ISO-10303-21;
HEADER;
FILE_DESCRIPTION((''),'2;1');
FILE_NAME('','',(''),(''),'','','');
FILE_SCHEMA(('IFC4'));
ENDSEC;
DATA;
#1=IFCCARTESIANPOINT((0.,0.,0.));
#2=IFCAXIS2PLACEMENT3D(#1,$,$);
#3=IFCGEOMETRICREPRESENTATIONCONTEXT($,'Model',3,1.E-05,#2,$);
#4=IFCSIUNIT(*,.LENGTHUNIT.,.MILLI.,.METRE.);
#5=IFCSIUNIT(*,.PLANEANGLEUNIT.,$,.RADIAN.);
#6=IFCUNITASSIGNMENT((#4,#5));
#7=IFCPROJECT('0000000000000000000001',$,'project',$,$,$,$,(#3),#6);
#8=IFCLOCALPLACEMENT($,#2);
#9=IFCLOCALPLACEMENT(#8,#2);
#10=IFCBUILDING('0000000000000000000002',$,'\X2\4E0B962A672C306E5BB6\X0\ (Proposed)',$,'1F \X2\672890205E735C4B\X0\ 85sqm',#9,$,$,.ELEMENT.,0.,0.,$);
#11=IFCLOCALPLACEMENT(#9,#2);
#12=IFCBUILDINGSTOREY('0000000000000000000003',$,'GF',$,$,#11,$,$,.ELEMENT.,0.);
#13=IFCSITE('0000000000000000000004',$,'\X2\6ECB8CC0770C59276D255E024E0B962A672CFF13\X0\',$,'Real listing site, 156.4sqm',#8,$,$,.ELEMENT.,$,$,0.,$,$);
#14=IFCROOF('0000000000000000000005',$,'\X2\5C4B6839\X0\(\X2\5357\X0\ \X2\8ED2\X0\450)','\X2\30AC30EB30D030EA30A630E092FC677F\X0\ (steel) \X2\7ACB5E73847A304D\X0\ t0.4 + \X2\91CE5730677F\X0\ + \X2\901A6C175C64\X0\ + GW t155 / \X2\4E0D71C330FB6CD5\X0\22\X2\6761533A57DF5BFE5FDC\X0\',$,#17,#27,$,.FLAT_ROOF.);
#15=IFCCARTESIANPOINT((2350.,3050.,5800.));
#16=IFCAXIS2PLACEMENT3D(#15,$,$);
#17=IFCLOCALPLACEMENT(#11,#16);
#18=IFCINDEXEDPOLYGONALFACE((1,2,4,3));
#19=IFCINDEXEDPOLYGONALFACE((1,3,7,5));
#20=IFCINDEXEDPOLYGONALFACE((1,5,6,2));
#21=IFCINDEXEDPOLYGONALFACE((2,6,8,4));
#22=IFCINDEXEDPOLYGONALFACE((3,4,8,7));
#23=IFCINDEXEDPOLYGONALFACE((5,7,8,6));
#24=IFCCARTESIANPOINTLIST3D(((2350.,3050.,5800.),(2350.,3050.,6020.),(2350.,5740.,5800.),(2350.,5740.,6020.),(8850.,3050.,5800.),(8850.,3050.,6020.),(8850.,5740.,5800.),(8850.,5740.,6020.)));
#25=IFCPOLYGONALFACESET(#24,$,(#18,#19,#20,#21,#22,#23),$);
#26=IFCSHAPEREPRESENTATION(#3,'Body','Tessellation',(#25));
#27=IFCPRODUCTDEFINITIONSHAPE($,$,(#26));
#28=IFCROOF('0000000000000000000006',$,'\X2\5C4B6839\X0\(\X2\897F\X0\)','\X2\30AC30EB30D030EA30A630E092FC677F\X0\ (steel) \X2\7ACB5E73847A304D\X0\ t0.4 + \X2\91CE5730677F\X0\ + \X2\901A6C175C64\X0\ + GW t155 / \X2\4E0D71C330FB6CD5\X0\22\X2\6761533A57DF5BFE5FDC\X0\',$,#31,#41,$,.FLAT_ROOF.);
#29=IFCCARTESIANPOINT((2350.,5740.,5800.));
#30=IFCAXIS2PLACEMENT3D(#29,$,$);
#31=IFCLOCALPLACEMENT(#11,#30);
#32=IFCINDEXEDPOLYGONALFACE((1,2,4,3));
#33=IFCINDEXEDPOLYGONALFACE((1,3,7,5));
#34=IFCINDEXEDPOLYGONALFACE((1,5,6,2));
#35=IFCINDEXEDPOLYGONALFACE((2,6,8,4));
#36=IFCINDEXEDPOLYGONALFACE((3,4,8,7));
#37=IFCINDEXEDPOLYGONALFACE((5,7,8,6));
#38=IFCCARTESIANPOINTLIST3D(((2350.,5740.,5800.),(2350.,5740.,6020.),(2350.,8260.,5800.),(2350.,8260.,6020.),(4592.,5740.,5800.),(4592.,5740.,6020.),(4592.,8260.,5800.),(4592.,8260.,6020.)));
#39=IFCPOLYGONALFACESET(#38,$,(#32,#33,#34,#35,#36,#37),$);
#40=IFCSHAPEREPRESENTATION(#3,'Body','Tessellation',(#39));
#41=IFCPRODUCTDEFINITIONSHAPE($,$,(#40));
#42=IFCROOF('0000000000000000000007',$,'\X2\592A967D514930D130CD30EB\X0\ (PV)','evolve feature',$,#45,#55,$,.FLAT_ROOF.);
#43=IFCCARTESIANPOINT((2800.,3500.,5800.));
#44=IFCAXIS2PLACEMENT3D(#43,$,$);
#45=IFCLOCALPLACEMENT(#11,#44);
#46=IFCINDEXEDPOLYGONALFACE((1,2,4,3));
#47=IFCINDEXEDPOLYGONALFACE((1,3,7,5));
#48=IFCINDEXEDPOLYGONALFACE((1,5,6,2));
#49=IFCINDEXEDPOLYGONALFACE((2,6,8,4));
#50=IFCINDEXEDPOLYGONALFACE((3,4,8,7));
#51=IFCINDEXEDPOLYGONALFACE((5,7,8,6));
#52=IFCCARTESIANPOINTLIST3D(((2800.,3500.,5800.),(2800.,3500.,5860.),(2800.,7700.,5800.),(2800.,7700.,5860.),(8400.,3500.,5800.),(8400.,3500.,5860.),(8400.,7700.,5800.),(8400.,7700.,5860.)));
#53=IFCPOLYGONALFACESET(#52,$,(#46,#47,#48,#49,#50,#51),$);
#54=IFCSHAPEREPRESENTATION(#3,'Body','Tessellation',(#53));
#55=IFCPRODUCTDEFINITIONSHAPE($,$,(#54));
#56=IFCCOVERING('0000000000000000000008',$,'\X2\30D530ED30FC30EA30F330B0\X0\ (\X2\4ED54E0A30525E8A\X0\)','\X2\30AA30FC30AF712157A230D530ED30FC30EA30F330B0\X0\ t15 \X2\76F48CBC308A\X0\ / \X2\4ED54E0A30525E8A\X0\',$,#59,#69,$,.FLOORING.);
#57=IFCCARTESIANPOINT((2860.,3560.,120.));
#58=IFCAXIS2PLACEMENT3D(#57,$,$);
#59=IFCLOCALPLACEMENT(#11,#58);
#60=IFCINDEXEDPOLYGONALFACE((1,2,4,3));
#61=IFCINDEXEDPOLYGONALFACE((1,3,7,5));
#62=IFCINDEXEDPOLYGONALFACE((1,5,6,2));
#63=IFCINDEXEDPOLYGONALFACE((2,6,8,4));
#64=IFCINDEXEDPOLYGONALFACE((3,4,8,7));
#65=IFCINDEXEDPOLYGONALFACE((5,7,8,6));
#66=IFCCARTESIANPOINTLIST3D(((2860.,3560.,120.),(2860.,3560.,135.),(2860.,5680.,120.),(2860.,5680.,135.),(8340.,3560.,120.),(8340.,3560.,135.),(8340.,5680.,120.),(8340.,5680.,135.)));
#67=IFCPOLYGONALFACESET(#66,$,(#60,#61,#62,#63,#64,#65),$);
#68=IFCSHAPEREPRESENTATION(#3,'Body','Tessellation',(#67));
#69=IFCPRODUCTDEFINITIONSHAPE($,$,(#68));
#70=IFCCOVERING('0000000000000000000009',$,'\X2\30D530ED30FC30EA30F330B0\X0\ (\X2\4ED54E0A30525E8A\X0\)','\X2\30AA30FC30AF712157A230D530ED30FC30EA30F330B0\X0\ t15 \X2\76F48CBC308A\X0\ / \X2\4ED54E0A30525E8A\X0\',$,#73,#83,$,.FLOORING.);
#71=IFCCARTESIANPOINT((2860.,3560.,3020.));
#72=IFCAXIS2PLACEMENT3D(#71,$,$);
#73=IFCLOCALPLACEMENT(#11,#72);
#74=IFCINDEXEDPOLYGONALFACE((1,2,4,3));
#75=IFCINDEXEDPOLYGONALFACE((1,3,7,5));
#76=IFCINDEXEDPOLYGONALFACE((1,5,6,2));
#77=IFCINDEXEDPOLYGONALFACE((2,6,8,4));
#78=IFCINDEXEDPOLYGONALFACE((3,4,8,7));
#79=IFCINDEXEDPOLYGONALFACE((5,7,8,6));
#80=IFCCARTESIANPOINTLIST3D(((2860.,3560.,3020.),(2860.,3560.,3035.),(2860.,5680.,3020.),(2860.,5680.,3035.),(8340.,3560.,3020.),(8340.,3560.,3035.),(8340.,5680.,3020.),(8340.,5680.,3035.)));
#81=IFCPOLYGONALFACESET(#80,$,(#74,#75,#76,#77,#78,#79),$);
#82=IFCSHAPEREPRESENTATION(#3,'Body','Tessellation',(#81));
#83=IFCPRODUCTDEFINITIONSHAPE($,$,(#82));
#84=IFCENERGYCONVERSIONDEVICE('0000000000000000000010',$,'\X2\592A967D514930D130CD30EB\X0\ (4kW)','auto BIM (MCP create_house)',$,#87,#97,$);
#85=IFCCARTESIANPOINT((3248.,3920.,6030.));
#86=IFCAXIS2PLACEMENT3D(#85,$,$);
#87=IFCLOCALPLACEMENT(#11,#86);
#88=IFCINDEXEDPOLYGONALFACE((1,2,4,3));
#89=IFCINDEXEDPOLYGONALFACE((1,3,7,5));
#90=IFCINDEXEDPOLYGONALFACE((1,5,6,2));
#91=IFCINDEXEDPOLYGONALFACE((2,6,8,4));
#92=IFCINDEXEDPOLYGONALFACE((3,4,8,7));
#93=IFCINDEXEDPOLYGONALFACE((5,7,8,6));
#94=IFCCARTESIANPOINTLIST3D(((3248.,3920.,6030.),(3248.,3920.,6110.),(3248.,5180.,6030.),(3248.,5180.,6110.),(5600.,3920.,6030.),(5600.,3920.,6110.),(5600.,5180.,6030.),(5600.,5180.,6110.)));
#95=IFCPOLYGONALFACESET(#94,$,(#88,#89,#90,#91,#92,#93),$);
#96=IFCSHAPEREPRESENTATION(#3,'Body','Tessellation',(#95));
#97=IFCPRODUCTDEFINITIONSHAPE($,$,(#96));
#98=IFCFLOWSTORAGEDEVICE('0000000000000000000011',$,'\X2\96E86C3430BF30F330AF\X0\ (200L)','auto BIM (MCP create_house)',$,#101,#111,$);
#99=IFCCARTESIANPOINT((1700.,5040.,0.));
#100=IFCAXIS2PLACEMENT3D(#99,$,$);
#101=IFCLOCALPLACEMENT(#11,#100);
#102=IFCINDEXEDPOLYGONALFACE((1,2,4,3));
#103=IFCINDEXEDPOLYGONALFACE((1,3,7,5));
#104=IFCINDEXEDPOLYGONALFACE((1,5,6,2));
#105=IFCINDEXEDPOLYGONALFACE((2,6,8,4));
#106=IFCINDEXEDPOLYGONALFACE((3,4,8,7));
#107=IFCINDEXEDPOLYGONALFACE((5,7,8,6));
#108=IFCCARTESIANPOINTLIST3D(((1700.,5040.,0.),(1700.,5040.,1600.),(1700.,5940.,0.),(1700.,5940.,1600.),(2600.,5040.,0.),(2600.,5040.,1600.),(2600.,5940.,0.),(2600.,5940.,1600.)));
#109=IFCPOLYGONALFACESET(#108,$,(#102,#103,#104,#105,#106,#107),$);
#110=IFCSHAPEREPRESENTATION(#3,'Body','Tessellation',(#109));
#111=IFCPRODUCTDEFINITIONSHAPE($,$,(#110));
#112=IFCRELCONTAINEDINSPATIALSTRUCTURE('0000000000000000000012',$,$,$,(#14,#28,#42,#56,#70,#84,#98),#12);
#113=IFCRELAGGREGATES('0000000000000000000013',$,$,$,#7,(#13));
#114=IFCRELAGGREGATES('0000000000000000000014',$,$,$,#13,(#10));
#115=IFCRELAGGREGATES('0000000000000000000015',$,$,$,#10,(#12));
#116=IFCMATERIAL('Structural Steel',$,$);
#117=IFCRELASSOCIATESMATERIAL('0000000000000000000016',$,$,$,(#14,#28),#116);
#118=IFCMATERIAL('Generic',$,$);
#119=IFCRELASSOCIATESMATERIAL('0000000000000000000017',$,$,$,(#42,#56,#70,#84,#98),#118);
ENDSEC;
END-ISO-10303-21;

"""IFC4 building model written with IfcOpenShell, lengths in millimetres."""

from ifc_helpers import new_model, si_unit, frame, frame_2d, origin, place, context, project, spatial, rectangle, extrude, material, element, save


model = new_model("IFC4")

# Units and contexts
model_context = context("Model", 3, precision=1e-05, world=origin())
ifc_project = project(units=[si_unit("LENGTHUNIT", "METRE", prefix="MILLI"), si_unit("PLANEANGLEUNIT", "RADIAN")], contexts=[model_context])

# Site, building, storey
site_placement = place(None, origin())
site = spatial("IfcSite", under=ifc_project, at=site_placement, Name="滋賀県大津市下阪本３", ObjectType="Real listing site, 156.4sqm", CompositionType="ELEMENT", RefElevation=0.0)
building_placement = place(site_placement, origin())
building = spatial("IfcBuilding", under=site, at=building_placement, Name="下阪本の家 (Proposed)", ObjectType="1F 木造平屋 85sqm", CompositionType="ELEMENT", ElevationOfRefHeight=0.0, ElevationOfTerrain=0.0)
storey_placement = place(building_placement, origin())
storey = spatial("IfcBuildingStorey", under=building, at=storey_placement, Name="GF", CompositionType="ELEMENT", Elevation=0.0)

# Shared definitions
ifc_material_1 = material(Name="Generic")

# Roofs
ifc_material_2 = material(Name="Structural Steel")
roof_1_placement = place(storey_placement, frame((2350.0, 3050.0, 5800.0)))
element("IfcRoof", 1, at=roof_1_placement, inside=storey, material=ifc_material_2, Name="屋根(南 軒450)", Description="ガルバリウム鋼板 (steel) 立平葺き t0.4 + 野地板 + 通気層 + GW t155 / 不燃・法22条区域対応", PredefinedType="FLAT_ROOF", context=model_context, shape_type="SweptSolid", body=[
    extrude(rectangle(XDim=6500.0, YDim=2690.0, at=frame_2d((3250.0, 1345.0))), frame((2350.0, 3050.0, 5800.0)), (0.0, 0.0, 1.0), 220.0),
])
roof_2_placement = place(storey_placement, frame((2350.0, 5740.0, 5800.0)))
element("IfcRoof", 2, at=roof_2_placement, inside=storey, material=ifc_material_2, Name="屋根(西)", Description="ガルバリウム鋼板 (steel) 立平葺き t0.4 + 野地板 + 通気層 + GW t155 / 不燃・法22条区域対応", PredefinedType="FLAT_ROOF", context=model_context, shape_type="SweptSolid", body=[
    extrude(rectangle(XDim=2242.0, YDim=2520.0, at=frame_2d((1121.0, 1260.0))), frame((2350.0, 5740.0, 5800.0)), (0.0, 0.0, 1.0), 220.0),
])
roof_3_placement = place(storey_placement, frame((2800.0, 3500.0, 5800.0)))
element("IfcRoof", 3, at=roof_3_placement, inside=storey, material=ifc_material_1, Name="太陽光パネル (PV)", Description="evolve feature", PredefinedType="FLAT_ROOF", context=model_context, shape_type="SweptSolid", body=[
    extrude(rectangle(XDim=5600.0, YDim=4200.0, at=frame_2d((2800.0, 2100.0))), frame((2800.0, 3500.0, 5800.0)), (0.0, 0.0, 1.0), 60.0),
])

# Coverings
covering_1_placement = place(storey_placement, frame((2860.0, 3560.0, 120.0)))
element("IfcCovering", 4, at=covering_1_placement, inside=storey, material=ifc_material_1, Name="フローリング (仕上げ床)", Description="オーク無垢フローリング t15 直貼り / 仕上げ床", PredefinedType="FLOORING", context=model_context, shape_type="SweptSolid", body=[
    extrude(rectangle(XDim=5480.0, YDim=2120.0, at=frame_2d((2740.0, 1060.0))), frame((2860.0, 3560.0, 120.0)), (0.0, 0.0, 1.0), 15.0),
])
covering_2_placement = place(storey_placement, frame((2860.0, 3560.0, 3020.0)))
element("IfcCovering", 5, at=covering_2_placement, inside=storey, material=ifc_material_1, Name="フローリング (仕上げ床)", Description="オーク無垢フローリング t15 直貼り / 仕上げ床", PredefinedType="FLOORING", context=model_context, shape_type="SweptSolid", body=[
    extrude(rectangle(XDim=5480.0, YDim=2120.0, at=frame_2d((2740.0, 1060.0))), frame((2860.0, 3560.0, 3020.0)), (0.0, 0.0, 1.0), 15.0),
])

# Energy conversion device
energy_conversion_device_placement = place(storey_placement, frame((3248.0, 3920.0, 6030.0)))
element("IfcEnergyConversionDevice", 6, at=energy_conversion_device_placement, inside=storey, material=ifc_material_1, Name="太陽光パネル (4kW)", Description="auto BIM (MCP create_house)", context=model_context, shape_type="SweptSolid", body=[
    extrude(rectangle(XDim=2352.0, YDim=1260.0, at=frame_2d((1176.0, 630.0))), frame((3248.0, 3920.0, 6030.0)), (0.0, 0.0, 1.0), 80.0),
])

# Flow storage device
flow_storage_device_placement = place(storey_placement, frame((1700.0, 5040.0, 0.0)))
element("IfcFlowStorageDevice", 7, at=flow_storage_device_placement, inside=storey, material=ifc_material_1, Name="雨水タンク (200L)", Description="auto BIM (MCP create_house)", context=model_context, shape_type="SweptSolid", body=[
    extrude(rectangle(XDim=900.0, YDim=900.0, at=frame_2d((450.0, 450.0))), frame((1700.0, 5040.0, 0.0)), (0.0, 0.0, 1.0), 1600.0),
])

save(model, "model.ifc")
